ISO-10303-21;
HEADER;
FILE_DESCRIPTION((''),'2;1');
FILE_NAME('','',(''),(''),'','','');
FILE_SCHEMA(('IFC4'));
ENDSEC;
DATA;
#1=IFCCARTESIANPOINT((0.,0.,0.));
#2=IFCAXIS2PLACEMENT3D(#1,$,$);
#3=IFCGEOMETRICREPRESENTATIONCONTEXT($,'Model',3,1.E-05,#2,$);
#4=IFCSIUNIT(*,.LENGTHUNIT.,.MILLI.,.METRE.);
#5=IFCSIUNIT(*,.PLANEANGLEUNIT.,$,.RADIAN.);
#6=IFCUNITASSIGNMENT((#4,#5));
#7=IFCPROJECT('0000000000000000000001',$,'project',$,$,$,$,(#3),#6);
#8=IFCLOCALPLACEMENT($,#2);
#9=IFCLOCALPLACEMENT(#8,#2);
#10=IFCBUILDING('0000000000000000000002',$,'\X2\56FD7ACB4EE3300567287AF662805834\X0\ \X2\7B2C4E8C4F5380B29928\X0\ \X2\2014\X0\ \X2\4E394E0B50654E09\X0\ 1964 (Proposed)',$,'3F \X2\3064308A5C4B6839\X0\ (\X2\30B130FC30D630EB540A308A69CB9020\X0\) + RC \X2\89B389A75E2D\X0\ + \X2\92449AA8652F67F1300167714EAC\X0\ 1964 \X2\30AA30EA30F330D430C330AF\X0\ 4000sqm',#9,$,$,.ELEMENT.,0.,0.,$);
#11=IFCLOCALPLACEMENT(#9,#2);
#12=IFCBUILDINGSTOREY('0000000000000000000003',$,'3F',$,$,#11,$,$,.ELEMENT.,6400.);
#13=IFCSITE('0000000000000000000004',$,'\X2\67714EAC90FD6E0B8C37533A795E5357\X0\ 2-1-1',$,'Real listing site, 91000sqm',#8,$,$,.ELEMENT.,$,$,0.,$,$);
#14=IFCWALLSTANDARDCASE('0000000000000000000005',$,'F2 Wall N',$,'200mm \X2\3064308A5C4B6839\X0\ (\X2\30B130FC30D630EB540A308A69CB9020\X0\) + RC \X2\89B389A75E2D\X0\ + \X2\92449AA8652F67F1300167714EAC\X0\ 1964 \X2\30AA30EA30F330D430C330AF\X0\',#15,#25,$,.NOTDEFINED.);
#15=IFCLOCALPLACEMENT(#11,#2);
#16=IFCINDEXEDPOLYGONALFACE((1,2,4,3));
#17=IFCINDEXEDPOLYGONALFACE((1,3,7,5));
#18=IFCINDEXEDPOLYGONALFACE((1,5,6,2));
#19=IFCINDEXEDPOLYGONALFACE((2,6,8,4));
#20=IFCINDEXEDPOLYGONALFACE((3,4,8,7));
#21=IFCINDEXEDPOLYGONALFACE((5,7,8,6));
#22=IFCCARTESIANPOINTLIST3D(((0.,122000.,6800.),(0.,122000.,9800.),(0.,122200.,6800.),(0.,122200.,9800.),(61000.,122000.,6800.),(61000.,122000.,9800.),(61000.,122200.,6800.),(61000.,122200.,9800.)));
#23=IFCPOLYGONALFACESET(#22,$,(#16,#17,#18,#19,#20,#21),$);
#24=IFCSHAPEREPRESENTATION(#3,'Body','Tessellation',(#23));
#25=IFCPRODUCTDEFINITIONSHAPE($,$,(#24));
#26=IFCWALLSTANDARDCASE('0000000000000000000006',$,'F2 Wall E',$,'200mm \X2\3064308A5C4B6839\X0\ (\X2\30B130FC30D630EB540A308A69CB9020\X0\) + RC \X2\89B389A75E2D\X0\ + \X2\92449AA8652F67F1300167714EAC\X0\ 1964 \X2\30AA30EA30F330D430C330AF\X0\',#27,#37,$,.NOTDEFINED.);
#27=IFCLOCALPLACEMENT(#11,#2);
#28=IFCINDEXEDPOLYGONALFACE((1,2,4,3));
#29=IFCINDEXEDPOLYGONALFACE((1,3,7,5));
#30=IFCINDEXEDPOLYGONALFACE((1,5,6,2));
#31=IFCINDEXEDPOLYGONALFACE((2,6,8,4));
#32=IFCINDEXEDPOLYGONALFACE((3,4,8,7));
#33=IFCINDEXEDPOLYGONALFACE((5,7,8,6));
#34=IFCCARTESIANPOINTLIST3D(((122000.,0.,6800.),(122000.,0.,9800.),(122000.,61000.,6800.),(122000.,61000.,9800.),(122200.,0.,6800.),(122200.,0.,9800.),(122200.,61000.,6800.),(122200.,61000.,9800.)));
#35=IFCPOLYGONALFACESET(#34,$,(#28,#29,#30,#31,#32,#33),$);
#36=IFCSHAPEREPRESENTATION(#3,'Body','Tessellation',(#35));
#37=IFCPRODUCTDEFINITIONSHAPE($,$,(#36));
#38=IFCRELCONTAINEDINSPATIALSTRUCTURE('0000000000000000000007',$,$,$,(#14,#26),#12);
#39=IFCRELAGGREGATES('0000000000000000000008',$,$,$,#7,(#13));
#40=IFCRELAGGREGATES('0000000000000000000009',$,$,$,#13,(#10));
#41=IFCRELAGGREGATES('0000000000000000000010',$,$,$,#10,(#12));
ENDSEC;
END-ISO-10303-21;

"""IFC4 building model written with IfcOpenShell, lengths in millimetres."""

from ifc_helpers import new_model, si_unit, frame, frame_2d, origin, place, context, project, spatial, rectangle, extrude, element, save


model = new_model("IFC4")

# Units and contexts
model_context = context("Model", 3, precision=1e-05, world=origin())
ifc_project = project(units=[si_unit("LENGTHUNIT", "METRE", prefix="MILLI"), si_unit("PLANEANGLEUNIT", "RADIAN")], contexts=[model_context])

# Site, building, storey
site_placement = place(None, origin())
site = spatial("IfcSite", under=ifc_project, at=site_placement, Name="東京都渋谷区神南 2-1-1", ObjectType="Real listing site, 91000sqm", CompositionType="ELEMENT", RefElevation=0.0)
building_placement = place(site_placement, origin())
building = spatial("IfcBuilding", under=site, at=building_placement, Name="国立代々木競技場 第二体育館 — 丹下健三 1964 (Proposed)", ObjectType="3F つり屋根 (ケーブル吊り構造) + RC 観覧席 + 鉄骨支柱、東京 1964 オリンピック 4000sqm", CompositionType="ELEMENT", ElevationOfRefHeight=0.0, ElevationOfTerrain=0.0)
storey_placement = place(building_placement, origin())
storey = spatial("IfcBuildingStorey", under=building, at=storey_placement, Name="3F", CompositionType="ELEMENT", Elevation=6400.0)

# Shared definitions
placement = place(building_placement, origin())

# Walls
wall_1_placement = place(placement, frame((0.0, 61000.0, 3400.0)))
element("IfcWallStandardCase", 1, at=wall_1_placement, inside=storey, Name="F2 Wall N", ObjectType="200mm つり屋根 (ケーブル吊り構造) + RC 観覧席 + 鉄骨支柱、東京 1964 オリンピック", PredefinedType="NOTDEFINED", context=model_context, shape_type="SweptSolid", body=[
    extrude(rectangle(XDim=61000.0, YDim=200.0, at=frame_2d((30500.0, 100.0))), frame((0.0, 61000.0, 3400.0)), (0.0, 0.0, 1.0), 3000.0),
])
wall_2_placement = place(placement, frame((61000.0, 0.0, 3400.0)))
element("IfcWallStandardCase", 2, at=wall_2_placement, inside=storey, Name="F2 Wall E", ObjectType="200mm つり屋根 (ケーブル吊り構造) + RC 観覧席 + 鉄骨支柱、東京 1964 オリンピック", PredefinedType="NOTDEFINED", context=model_context, shape_type="SweptSolid", body=[
    extrude(rectangle(XDim=200.0, YDim=61000.0, at=frame_2d((100.0, 30500.0))), frame((61000.0, 0.0, 3400.0)), (0.0, 0.0, 1.0), 3000.0),
])

save(model, "model.ifc")
